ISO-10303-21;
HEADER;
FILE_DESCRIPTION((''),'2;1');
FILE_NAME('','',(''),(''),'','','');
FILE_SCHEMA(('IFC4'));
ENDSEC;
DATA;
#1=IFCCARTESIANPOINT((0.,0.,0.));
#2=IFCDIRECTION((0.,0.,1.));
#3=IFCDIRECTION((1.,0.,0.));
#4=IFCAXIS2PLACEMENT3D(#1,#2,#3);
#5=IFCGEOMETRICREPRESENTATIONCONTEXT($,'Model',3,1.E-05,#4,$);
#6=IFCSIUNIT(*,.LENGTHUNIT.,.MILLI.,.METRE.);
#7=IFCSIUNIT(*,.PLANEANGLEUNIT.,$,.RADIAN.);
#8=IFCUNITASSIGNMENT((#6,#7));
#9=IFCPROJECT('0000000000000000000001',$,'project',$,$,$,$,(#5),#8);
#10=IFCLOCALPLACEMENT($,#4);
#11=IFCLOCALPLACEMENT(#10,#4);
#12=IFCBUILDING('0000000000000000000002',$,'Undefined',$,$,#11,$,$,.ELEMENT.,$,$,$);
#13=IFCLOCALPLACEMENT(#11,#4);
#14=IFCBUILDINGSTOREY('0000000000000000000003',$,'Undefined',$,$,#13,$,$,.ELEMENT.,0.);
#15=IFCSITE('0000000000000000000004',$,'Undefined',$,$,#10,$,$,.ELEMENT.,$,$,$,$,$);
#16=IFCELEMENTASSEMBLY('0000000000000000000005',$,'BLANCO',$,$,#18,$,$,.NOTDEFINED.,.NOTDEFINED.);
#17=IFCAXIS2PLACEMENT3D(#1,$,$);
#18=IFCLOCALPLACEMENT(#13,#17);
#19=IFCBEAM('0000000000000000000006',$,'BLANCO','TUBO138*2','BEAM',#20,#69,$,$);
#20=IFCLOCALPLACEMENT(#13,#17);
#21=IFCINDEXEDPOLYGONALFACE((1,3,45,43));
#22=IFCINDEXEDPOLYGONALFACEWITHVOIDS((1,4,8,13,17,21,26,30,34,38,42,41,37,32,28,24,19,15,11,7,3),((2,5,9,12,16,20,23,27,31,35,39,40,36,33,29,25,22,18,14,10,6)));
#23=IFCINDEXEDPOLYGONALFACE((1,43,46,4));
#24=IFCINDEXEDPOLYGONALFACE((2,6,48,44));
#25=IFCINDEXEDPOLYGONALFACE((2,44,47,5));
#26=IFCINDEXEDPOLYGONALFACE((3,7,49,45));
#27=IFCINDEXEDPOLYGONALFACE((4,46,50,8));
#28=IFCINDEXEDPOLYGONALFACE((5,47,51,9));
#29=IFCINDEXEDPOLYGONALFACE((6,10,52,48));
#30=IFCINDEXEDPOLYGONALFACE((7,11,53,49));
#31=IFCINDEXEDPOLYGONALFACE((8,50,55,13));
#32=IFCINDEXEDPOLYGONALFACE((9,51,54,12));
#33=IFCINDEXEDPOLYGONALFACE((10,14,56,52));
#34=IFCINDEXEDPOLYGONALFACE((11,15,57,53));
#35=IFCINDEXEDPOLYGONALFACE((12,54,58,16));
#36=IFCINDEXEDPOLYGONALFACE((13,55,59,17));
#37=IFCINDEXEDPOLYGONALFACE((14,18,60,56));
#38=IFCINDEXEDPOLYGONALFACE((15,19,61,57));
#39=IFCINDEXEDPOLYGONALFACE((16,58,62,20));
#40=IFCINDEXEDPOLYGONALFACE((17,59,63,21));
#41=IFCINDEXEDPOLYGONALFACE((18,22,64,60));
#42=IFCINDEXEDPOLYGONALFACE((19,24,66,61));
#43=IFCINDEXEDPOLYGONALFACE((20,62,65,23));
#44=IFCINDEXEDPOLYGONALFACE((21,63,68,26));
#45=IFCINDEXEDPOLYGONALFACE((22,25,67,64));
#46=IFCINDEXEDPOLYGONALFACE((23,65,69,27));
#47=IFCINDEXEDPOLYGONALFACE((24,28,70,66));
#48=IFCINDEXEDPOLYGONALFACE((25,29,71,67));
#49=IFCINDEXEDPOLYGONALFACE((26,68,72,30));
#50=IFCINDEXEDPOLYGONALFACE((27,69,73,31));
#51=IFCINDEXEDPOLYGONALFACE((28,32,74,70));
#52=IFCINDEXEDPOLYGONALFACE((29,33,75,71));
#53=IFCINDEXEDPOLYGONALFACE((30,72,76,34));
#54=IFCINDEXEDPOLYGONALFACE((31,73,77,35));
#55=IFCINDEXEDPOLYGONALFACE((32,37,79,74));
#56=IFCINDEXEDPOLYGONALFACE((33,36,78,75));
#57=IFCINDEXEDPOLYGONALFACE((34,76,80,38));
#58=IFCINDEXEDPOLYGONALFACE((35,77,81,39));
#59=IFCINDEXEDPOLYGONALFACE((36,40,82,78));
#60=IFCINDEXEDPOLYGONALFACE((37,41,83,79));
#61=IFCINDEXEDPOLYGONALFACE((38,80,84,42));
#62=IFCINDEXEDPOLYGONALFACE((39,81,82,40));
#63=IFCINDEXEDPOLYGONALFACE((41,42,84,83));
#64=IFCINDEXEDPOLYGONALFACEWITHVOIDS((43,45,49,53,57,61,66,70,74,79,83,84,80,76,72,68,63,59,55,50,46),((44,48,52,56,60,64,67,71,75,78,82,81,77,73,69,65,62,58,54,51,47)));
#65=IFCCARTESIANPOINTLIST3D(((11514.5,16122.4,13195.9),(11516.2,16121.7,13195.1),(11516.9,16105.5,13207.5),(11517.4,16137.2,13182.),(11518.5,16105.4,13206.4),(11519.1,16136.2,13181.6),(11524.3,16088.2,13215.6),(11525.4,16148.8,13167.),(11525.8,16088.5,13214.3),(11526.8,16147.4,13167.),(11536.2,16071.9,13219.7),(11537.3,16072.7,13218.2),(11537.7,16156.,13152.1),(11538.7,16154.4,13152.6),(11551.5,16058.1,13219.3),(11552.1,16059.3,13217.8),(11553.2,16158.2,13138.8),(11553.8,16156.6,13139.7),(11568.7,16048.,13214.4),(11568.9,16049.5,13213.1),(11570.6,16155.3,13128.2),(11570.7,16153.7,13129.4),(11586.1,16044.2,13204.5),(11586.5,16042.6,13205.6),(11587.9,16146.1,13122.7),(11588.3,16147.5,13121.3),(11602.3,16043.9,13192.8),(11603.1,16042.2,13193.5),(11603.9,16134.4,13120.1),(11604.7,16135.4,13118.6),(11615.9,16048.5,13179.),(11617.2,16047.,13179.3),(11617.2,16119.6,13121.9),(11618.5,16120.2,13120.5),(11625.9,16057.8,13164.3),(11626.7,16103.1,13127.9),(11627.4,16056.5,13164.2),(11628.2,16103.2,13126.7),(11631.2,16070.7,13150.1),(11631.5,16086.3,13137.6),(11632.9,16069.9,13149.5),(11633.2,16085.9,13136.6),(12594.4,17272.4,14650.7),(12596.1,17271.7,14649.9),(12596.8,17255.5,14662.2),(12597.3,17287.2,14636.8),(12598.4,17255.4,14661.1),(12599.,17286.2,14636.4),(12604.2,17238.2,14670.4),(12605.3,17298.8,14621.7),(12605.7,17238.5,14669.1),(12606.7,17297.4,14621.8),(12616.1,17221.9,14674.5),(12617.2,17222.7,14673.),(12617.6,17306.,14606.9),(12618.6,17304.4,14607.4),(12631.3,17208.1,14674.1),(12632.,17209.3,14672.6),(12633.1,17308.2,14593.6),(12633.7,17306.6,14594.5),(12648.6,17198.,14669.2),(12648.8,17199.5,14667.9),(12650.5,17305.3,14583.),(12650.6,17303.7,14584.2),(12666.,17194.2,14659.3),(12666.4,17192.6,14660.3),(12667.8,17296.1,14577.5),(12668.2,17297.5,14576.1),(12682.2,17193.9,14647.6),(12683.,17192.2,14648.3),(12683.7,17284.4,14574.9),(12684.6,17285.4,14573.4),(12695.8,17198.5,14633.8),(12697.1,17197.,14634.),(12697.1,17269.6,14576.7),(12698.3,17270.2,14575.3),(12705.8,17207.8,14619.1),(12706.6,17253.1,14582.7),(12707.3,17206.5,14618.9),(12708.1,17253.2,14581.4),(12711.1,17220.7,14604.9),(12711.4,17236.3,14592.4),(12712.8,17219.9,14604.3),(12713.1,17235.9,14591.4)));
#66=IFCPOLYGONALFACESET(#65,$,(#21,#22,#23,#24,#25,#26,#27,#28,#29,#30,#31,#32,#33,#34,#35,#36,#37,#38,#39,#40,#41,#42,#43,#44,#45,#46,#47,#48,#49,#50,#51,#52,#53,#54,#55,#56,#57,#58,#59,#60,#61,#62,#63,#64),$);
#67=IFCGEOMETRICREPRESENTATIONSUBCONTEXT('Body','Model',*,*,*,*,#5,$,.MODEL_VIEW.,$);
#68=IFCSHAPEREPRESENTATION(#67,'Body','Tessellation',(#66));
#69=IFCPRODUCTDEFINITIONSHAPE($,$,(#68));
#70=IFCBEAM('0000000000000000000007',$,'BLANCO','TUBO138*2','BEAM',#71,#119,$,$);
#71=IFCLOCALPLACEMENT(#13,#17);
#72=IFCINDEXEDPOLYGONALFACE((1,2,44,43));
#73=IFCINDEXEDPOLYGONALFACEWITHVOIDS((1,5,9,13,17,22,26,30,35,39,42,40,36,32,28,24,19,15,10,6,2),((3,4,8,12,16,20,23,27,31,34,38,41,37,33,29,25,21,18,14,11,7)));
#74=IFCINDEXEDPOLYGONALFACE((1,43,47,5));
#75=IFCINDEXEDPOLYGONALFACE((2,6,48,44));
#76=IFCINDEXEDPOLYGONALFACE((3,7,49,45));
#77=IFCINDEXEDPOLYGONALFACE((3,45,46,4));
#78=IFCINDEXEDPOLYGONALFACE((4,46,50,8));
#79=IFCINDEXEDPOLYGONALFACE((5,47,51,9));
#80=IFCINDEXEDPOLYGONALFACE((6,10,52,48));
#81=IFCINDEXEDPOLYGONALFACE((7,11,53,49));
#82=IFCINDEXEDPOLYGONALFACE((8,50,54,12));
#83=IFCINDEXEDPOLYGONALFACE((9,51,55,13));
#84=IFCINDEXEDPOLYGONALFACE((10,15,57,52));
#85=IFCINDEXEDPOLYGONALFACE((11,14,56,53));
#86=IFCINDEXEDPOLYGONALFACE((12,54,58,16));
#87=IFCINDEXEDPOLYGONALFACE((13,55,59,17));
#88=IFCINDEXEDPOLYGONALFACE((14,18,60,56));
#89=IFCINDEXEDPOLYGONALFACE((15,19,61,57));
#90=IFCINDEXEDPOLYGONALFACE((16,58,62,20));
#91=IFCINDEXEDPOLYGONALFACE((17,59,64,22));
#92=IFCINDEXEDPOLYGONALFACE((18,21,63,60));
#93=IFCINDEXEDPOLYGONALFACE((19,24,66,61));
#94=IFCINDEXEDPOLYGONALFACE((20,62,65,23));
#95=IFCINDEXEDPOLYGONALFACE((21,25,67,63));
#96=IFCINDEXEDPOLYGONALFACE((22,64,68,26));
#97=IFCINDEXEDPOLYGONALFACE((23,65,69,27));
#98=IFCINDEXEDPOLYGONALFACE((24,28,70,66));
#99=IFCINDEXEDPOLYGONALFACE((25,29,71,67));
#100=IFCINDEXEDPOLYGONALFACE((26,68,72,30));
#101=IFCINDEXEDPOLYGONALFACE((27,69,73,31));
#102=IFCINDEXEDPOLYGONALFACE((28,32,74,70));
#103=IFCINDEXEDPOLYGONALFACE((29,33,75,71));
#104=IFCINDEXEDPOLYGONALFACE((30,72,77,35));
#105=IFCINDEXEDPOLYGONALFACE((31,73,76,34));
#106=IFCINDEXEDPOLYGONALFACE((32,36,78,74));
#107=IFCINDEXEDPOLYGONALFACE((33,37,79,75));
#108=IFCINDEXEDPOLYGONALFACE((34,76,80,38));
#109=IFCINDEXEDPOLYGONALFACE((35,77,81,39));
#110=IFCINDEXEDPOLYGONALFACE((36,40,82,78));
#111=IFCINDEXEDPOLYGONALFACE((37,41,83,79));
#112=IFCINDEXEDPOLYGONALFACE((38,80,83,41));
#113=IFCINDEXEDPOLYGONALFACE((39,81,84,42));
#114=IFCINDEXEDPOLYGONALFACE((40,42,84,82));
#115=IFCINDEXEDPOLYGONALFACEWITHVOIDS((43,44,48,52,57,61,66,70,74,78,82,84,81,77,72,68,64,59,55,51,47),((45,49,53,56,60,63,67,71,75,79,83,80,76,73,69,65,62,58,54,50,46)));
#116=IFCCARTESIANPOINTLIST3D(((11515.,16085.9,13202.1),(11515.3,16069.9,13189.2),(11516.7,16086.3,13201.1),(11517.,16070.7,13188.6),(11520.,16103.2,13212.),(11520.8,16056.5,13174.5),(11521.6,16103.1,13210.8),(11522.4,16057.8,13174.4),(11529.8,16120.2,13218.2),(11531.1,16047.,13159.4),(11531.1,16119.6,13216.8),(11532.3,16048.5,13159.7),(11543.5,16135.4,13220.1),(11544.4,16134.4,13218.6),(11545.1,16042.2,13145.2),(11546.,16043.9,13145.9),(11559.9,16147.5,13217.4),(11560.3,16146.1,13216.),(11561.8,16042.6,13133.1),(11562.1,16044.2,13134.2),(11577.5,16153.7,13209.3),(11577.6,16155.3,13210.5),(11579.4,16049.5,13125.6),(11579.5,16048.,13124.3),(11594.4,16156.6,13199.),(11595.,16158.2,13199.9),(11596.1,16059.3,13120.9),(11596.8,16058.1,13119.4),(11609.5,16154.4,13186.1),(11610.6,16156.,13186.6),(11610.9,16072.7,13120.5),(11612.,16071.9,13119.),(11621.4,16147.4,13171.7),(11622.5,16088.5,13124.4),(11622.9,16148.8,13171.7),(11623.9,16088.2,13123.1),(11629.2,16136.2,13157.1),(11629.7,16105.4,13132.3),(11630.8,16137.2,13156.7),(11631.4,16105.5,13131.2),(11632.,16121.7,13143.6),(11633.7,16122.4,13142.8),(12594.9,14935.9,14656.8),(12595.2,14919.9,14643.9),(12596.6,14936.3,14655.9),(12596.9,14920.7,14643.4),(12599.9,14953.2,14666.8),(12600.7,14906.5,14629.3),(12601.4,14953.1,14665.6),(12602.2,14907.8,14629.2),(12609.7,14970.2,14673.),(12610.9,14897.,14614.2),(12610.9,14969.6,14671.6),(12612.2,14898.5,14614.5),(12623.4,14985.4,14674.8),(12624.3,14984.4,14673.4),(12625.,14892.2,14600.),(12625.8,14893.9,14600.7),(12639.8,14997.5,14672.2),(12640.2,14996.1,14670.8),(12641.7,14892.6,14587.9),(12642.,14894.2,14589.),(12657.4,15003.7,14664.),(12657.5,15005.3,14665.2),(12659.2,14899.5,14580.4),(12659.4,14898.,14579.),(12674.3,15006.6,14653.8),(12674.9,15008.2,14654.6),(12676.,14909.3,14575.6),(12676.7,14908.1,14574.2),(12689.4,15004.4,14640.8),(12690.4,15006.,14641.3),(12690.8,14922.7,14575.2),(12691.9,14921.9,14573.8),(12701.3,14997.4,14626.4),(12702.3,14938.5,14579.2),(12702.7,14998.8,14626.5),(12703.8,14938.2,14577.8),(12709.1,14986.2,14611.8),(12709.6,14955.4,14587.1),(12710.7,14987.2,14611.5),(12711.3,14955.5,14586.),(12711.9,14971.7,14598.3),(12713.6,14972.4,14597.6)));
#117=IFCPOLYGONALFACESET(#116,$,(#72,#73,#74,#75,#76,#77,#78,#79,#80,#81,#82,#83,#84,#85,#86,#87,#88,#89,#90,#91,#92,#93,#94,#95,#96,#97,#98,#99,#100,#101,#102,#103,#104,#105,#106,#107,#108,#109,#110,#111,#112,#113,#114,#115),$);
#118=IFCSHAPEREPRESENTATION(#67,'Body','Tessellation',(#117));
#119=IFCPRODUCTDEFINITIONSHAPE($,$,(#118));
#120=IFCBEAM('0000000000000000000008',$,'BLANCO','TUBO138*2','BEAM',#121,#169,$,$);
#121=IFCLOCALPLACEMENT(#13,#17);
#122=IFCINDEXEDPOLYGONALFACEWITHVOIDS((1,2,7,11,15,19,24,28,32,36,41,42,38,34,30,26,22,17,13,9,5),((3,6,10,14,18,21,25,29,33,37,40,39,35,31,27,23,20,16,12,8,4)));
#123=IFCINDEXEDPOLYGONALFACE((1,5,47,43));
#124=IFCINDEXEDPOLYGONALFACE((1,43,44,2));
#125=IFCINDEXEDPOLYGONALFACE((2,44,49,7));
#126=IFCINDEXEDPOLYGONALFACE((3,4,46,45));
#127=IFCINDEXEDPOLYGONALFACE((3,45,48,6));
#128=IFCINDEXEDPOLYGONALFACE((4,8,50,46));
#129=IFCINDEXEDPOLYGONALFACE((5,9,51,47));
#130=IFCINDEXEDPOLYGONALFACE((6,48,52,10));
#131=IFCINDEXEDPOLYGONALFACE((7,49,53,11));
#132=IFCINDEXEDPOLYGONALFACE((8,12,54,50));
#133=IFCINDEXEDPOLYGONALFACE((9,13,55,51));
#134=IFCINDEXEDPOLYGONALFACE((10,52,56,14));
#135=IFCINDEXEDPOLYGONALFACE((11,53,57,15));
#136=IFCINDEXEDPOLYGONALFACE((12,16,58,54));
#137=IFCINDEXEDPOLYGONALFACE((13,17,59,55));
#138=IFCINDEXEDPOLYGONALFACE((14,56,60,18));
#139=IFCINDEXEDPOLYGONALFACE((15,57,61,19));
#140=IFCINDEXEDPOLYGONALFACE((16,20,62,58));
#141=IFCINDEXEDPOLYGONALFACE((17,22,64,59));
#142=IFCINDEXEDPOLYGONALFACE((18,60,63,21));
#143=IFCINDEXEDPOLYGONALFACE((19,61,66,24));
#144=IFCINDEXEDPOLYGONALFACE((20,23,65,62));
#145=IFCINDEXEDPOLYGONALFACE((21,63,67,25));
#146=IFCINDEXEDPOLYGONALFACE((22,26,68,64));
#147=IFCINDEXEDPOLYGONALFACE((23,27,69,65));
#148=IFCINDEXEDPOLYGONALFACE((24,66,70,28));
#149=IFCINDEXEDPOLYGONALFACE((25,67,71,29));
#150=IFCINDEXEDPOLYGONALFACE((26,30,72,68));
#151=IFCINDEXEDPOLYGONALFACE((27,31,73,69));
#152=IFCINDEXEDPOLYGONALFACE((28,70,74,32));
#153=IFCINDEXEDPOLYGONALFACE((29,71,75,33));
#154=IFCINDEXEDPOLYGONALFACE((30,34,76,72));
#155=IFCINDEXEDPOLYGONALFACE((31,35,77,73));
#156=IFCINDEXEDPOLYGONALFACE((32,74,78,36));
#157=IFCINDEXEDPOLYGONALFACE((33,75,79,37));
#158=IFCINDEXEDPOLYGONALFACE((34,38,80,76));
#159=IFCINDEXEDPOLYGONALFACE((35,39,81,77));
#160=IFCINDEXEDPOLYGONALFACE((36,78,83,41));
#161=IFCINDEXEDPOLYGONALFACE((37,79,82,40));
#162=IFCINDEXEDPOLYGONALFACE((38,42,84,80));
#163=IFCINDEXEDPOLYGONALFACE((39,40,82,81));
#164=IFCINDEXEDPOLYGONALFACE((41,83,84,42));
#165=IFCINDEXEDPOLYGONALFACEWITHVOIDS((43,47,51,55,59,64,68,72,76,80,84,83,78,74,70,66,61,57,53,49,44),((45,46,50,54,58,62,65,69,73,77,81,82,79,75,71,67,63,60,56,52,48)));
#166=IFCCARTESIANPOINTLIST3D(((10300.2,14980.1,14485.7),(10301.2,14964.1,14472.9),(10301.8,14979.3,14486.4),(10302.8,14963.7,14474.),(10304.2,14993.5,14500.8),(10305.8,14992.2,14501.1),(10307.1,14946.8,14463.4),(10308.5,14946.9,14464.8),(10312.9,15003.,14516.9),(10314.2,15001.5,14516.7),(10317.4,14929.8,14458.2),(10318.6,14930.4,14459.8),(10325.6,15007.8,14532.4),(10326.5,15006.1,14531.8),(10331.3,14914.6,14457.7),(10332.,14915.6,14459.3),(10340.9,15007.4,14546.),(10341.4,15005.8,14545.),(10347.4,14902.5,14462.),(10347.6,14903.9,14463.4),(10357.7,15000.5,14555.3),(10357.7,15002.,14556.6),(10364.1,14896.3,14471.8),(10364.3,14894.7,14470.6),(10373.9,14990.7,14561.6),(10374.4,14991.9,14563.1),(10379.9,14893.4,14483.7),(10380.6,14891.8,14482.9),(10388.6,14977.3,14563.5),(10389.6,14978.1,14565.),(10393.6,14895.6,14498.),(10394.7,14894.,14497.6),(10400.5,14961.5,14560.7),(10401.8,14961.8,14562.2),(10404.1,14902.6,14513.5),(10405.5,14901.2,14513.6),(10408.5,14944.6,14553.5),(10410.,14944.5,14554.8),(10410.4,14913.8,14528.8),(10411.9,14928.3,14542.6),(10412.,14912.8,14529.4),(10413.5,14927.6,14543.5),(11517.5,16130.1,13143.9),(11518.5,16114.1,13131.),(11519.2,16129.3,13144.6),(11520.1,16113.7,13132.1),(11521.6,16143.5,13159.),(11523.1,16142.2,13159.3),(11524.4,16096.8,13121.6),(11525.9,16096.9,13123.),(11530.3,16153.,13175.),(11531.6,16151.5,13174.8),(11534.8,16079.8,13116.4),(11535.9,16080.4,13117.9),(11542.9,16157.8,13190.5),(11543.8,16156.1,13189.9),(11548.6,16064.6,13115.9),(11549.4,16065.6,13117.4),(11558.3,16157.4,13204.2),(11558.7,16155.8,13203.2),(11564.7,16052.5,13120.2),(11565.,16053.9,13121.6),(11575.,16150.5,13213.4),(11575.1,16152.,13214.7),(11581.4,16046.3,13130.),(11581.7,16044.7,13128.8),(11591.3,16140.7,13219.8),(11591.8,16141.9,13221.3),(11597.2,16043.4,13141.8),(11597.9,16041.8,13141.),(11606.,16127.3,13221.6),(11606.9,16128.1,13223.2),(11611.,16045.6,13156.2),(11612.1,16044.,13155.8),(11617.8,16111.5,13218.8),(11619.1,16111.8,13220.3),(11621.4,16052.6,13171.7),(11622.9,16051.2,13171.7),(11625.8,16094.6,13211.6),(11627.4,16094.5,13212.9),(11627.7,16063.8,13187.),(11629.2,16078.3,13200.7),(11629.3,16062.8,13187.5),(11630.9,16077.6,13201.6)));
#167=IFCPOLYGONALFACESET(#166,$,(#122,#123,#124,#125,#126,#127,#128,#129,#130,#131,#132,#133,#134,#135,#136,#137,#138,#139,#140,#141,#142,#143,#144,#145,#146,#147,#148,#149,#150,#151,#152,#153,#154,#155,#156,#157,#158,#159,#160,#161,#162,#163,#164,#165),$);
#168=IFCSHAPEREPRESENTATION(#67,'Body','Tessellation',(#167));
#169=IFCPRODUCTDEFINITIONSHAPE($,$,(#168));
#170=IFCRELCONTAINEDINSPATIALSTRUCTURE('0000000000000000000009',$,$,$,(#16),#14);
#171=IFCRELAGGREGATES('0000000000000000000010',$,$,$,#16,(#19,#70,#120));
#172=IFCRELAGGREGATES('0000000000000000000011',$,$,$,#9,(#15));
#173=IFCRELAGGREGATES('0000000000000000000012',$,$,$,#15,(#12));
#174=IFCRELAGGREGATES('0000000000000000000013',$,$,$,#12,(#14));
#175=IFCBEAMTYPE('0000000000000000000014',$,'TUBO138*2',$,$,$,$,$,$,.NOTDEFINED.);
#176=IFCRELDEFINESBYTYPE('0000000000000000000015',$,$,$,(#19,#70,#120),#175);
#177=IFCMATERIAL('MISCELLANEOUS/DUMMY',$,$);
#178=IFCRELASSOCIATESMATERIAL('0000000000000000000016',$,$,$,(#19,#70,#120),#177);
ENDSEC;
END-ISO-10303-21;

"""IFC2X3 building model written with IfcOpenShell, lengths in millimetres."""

from ifc_helpers import new_model, si_unit, frame, origin_with_axes, origin_2d_with_axis, place, context, subcontext, project, spatial, hollow_circle, extrude, material, type_object, element, aggregate, save


model = new_model("IFC2X3")

# Units and contexts
model_context = context("Model", 3, precision=1e-05, world=origin_with_axes())
body_context = subcontext(model_context, "Body", "Model", "MODEL_VIEW")
ifc_project = project(units=[si_unit("LENGTHUNIT", "METRE", prefix="MILLI"), si_unit("PLANEANGLEUNIT", "RADIAN")], contexts=[model_context])

# Site, building, storey
site_placement = place(None, origin_with_axes())
site = spatial("IfcSite", under=ifc_project, at=site_placement, Name="Undefined", CompositionType="ELEMENT")
building_placement = place(site_placement, origin_with_axes())
building = spatial("IfcBuilding", under=site, at=building_placement, Name="Undefined", CompositionType="ELEMENT")
storey_placement = place(building_placement, origin_with_axes())
storey = spatial("IfcBuildingStorey", under=building, at=storey_placement, Name="Undefined", CompositionType="ELEMENT", Elevation=0.0)

# Element assembly, beams
assembly_placement = place(storey_placement, origin_with_axes())
assembly = element("IfcElementAssembly", 1, at=assembly_placement, inside=storey, Name="BLANCO", AssemblyPlace="NOTDEFINED", PredefinedType="NOTDEFINED")
ifc_material = material(Name="MISCELLANEOUS/DUMMY")
beam_type = type_object("IfcBeamType", Name="TUBO138*2", PredefinedType="NOTDEFINED")
beam_1_placement = place(assembly_placement, frame((11574.1, 16100.0, 13169.4), z_axis=(0.497966, 0.461316, -0.734314), x_axis=(0.503224, 0.535899, 0.677922)))
beam_1 = element("IfcBeam", 2, at=beam_1_placement, type_object=beam_type, material=ifc_material, Name="BLANCO", Description="TUBO138*2", ObjectType="BEAM", context=body_context, shape_type="SweptSolid", body=[
    extrude(hollow_circle(Radius=69.0, WallThickness=2.0, at=origin_2d_with_axis()), frame((2145.9, 0.0, 0.0), z_axis=(-1.0, 0.0, 0.0), x_axis=(0.0, -1.0, 0.0)), (0.0, 0.0, 1.0), 2145.9),
])
beam_2_placement = place(assembly_placement, frame((11574.1, 16100.0, 13169.4), z_axis=(0.497966, -0.461316, -0.734314), x_axis=(0.503224, -0.535899, 0.677922)))
beam_2 = element("IfcBeam", 3, at=beam_2_placement, type_object=beam_type, material=ifc_material, Name="BLANCO", Description="TUBO138*2", ObjectType="BEAM", context=body_context, shape_type="SweptSolid", body=[
    extrude(hollow_circle(Radius=69.0, WallThickness=2.0, at=origin_2d_with_axis()), frame((2145.9, 0.0, 0.0), z_axis=(-1.0, 0.0, 0.0), x_axis=(0.0, -1.0, 0.0)), (0.0, 0.0, 1.0), 2145.9),
])
beam_3_placement = place(assembly_placement, frame((11574.1, 16100.0, 13169.4), z_axis=(-0.423552, -0.461316, -0.77961), x_axis=(-0.567282, -0.535899, 0.625303)))
beam_3 = element("IfcBeam", 4, at=beam_3_placement, type_object=beam_type, material=ifc_material, Name="BLANCO", Description="TUBO138*2", ObjectType="BEAM", context=body_context, shape_type="SweptSolid", body=[
    extrude(hollow_circle(Radius=69.0, WallThickness=2.0, at=origin_2d_with_axis()), frame((2145.9, 0.0, 0.0), z_axis=(-1.0, 0.0, 0.0), x_axis=(0.0, -1.0, 0.0)), (0.0, 0.0, 1.0), 2145.9),
])
aggregate(assembly, [beam_1, beam_2, beam_3])

save(model, "model.ifc")
